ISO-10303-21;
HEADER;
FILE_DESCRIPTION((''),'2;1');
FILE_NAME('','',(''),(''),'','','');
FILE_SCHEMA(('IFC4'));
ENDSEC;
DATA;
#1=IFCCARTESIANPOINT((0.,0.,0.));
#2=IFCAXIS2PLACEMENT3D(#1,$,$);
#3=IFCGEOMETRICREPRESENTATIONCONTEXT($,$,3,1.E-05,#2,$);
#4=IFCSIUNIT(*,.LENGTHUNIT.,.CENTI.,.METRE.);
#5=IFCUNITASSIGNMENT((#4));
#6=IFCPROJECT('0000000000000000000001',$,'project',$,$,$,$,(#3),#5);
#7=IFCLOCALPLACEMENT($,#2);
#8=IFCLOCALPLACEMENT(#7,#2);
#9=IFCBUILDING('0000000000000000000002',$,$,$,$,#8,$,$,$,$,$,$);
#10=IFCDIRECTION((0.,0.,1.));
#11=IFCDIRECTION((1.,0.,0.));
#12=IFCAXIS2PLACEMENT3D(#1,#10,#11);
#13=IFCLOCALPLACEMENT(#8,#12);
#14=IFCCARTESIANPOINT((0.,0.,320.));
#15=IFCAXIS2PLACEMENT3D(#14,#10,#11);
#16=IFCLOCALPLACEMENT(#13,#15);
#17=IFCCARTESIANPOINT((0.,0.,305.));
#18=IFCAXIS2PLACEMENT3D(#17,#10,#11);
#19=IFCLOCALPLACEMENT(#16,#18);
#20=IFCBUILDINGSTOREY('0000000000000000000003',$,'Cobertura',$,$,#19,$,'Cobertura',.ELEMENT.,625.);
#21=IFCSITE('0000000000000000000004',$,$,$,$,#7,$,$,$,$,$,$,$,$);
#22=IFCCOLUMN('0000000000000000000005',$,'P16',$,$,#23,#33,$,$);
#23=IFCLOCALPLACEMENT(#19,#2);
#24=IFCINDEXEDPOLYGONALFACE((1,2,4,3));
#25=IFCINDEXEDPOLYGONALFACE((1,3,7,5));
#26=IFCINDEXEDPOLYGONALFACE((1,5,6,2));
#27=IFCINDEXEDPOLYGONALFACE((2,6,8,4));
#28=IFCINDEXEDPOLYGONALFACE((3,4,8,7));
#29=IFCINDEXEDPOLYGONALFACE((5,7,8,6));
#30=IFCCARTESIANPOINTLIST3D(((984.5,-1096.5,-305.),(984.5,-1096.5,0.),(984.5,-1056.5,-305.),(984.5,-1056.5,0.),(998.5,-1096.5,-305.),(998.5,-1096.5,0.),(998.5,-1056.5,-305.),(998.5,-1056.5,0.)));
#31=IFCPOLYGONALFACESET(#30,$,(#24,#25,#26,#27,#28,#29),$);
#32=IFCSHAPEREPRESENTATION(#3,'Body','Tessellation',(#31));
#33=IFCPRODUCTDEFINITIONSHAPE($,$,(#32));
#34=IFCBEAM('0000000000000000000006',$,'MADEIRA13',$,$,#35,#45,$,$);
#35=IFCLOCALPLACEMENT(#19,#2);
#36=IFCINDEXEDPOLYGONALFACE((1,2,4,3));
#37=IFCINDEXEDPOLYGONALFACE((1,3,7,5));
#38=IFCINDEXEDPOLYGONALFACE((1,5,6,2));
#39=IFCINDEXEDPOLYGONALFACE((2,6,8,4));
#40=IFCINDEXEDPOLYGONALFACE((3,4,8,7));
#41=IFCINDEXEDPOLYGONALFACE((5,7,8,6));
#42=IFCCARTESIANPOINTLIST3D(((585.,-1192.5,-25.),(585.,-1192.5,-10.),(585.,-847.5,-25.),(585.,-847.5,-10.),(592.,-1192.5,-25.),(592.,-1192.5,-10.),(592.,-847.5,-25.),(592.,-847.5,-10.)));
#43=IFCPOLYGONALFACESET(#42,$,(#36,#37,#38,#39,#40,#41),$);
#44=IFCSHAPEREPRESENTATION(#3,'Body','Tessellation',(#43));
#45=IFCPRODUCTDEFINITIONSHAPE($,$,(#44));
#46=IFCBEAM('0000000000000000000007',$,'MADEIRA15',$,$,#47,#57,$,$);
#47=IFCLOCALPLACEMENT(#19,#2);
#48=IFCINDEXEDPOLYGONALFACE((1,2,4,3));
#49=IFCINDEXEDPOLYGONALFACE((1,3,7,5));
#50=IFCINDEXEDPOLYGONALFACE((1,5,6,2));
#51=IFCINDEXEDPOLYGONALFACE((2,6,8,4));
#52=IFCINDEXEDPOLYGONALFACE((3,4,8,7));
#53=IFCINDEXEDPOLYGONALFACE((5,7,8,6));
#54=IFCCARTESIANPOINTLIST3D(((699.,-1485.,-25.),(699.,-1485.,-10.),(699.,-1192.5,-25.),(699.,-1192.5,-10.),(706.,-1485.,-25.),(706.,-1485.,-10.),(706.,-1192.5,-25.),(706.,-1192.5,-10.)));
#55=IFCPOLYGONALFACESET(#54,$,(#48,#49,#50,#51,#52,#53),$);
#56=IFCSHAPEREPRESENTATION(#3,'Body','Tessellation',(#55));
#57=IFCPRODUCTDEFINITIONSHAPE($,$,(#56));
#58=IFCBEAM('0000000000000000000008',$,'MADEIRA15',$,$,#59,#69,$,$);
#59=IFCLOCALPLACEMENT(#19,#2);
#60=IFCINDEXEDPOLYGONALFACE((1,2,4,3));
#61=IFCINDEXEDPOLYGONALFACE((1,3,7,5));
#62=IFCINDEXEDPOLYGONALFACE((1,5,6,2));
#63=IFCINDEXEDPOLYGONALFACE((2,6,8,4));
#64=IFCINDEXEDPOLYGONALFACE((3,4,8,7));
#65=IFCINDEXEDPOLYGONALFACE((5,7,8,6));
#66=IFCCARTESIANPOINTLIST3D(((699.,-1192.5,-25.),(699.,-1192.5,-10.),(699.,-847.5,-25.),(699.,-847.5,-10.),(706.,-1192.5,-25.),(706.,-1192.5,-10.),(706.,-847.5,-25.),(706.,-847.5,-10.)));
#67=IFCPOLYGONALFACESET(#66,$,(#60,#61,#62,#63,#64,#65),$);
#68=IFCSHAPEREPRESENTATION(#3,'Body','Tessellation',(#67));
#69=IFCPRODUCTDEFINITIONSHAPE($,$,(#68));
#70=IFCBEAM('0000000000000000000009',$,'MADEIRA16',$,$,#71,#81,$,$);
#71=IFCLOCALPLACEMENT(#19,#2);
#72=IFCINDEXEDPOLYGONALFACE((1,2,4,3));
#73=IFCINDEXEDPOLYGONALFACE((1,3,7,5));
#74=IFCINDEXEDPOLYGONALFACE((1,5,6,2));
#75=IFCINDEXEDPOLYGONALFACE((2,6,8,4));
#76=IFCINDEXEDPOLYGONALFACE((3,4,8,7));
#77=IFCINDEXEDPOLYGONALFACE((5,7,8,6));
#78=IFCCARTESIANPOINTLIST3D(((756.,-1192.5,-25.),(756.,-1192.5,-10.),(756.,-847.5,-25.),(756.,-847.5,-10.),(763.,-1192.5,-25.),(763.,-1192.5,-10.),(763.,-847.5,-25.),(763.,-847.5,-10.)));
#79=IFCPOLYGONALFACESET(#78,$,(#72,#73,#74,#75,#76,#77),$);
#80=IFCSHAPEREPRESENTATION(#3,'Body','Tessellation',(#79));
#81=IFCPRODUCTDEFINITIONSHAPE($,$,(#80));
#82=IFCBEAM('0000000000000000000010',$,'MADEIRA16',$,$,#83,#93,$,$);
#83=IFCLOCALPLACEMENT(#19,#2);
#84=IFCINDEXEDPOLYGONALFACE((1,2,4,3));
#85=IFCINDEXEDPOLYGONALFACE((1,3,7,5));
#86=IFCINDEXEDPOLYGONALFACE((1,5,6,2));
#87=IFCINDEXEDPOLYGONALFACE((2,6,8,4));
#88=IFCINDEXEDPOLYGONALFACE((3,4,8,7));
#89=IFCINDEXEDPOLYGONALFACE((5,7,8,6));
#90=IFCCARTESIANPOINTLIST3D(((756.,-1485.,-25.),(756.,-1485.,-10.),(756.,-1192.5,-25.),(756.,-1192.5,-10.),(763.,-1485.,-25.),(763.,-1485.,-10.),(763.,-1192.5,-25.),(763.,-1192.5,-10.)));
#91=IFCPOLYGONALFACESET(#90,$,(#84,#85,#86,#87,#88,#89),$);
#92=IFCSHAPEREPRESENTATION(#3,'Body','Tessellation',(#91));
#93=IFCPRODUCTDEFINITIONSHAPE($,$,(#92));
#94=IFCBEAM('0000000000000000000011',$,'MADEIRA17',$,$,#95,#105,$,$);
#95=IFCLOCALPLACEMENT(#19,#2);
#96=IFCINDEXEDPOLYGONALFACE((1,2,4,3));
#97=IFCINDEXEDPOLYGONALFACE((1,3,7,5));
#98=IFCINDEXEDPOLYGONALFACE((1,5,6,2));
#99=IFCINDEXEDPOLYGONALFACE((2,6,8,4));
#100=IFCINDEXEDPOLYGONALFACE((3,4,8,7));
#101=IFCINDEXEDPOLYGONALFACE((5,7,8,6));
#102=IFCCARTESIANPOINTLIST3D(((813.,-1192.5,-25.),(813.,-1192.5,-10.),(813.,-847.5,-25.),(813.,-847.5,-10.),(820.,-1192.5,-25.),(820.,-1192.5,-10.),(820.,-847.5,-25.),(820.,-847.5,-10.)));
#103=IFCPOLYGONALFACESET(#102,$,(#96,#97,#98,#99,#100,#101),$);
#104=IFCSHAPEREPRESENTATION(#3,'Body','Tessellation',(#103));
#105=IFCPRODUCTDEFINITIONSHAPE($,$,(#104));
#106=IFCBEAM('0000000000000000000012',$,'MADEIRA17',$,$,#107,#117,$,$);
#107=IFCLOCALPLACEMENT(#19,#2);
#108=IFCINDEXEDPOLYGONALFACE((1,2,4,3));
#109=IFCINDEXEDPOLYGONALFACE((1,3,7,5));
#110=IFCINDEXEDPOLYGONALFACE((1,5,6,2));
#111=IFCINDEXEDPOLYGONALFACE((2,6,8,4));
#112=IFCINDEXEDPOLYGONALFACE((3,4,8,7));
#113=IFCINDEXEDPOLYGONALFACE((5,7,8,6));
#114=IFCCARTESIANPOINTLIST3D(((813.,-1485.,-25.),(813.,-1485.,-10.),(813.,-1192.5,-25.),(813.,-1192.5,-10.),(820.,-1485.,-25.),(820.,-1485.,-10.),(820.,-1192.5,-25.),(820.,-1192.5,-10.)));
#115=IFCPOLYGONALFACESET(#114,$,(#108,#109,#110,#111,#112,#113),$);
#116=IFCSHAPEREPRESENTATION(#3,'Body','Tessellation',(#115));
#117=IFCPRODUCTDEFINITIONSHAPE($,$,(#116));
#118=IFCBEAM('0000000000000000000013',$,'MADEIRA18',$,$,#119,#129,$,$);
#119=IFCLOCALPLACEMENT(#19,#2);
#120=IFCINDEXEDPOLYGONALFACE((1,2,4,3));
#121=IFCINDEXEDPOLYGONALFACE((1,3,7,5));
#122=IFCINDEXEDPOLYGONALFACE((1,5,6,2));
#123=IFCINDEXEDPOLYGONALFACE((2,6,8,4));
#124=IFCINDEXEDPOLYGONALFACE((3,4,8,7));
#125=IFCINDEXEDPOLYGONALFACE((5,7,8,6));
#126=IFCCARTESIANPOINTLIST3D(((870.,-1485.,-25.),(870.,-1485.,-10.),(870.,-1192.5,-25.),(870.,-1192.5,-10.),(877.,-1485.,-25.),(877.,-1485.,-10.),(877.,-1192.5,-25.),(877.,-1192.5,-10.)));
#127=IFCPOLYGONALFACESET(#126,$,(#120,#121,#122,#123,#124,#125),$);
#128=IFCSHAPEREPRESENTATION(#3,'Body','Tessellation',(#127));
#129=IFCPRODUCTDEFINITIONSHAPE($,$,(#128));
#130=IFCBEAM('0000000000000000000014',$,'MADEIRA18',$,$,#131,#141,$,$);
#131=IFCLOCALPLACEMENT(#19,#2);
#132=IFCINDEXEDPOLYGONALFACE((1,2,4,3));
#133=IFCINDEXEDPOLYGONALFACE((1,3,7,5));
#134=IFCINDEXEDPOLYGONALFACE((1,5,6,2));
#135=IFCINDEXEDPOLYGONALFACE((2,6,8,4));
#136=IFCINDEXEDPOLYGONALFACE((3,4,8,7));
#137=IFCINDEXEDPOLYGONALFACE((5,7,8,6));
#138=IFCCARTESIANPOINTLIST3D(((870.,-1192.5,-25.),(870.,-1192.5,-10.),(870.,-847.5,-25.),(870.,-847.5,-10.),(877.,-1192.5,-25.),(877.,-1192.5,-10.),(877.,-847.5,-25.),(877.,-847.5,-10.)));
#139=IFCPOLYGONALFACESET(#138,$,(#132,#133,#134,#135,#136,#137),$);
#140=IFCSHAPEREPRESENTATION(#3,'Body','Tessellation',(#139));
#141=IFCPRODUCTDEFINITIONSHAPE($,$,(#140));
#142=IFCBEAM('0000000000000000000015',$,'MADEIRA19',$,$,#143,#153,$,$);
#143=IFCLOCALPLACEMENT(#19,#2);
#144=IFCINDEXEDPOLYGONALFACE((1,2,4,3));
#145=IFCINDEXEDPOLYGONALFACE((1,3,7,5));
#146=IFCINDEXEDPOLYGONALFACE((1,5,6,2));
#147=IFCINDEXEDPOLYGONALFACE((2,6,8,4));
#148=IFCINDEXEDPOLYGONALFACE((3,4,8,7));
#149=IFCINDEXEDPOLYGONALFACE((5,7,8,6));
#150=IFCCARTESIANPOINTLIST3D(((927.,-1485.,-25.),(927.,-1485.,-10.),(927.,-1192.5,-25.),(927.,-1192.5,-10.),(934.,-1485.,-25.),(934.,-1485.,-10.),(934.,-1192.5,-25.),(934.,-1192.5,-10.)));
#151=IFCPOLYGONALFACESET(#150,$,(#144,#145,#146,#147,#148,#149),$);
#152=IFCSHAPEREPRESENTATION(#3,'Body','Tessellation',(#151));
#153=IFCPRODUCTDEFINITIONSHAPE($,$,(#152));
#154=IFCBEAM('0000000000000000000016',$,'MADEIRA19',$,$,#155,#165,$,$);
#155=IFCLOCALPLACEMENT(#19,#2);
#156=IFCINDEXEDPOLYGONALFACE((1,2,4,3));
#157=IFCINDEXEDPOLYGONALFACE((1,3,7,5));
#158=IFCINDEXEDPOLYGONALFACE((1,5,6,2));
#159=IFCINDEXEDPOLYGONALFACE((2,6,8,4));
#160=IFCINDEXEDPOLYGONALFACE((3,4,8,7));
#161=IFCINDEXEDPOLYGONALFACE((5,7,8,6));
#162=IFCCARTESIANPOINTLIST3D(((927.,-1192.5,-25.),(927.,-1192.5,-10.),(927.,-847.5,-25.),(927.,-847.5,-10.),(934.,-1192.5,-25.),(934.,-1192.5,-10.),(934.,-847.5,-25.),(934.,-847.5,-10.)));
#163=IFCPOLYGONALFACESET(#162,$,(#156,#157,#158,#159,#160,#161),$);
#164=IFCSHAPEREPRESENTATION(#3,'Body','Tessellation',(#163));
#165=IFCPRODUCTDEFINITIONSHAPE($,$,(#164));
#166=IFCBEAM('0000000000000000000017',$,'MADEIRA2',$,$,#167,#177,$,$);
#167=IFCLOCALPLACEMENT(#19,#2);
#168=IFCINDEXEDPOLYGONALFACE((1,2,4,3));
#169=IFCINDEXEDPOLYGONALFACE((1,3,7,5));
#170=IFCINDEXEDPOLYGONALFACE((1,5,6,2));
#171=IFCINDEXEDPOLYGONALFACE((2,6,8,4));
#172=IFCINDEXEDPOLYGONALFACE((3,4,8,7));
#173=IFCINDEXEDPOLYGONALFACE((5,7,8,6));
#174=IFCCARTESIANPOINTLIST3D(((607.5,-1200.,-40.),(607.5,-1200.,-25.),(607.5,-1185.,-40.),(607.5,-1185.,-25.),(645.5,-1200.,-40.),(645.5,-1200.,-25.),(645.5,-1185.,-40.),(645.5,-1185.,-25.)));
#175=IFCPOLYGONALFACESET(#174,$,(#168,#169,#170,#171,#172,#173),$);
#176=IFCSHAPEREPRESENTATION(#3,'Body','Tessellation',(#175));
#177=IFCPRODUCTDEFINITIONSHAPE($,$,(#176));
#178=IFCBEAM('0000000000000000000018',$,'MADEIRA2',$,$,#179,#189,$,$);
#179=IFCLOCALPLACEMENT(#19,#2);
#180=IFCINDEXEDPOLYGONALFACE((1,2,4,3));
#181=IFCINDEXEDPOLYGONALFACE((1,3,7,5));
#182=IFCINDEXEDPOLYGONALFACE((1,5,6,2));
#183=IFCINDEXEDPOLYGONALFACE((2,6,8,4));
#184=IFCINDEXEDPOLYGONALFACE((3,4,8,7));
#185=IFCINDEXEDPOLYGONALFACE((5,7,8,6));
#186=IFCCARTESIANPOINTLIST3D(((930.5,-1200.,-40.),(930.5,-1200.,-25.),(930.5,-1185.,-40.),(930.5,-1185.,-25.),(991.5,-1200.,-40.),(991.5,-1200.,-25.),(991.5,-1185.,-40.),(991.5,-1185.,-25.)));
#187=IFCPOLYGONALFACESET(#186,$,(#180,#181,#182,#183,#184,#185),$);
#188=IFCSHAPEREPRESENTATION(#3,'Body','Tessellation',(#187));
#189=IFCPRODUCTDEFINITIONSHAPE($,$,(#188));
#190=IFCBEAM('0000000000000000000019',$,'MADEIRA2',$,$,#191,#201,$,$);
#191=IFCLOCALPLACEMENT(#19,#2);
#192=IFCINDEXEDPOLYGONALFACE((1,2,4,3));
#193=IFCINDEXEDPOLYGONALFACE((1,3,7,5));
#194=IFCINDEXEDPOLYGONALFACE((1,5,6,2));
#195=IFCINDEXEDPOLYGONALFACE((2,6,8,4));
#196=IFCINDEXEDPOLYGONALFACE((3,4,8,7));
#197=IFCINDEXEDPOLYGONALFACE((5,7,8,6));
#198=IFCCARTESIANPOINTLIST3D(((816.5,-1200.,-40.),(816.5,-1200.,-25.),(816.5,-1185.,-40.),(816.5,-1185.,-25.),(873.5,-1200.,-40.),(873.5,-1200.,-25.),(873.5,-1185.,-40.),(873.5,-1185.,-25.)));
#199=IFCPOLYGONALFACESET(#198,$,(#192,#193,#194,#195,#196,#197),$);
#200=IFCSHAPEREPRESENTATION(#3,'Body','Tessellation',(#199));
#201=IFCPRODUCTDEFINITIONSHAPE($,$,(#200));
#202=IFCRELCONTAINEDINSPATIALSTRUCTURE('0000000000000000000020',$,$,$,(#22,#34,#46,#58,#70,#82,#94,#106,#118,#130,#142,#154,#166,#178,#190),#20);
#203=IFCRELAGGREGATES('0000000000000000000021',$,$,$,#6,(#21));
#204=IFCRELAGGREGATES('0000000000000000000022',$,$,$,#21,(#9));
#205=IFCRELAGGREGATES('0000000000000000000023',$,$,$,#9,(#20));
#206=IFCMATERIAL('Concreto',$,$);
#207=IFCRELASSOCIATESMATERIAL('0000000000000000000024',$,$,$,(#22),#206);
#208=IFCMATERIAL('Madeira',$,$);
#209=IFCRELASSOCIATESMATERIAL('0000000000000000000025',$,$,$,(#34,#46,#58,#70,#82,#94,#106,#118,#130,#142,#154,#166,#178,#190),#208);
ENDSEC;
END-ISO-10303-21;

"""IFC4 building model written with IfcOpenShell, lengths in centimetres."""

from ifc_helpers import new_model, si_unit, frame, origin, origin_with_axes, place, context, project, spatial, polyline, outline, extrude, material, element, save


model = new_model("IFC4")

# Units and contexts
context_of_model = context(None, 3, precision=1e-05, world=origin())
ifc_project = project(units=[si_unit("LENGTHUNIT", "METRE", prefix="CENTI")], contexts=[context_of_model])

# Site, building, storey
site_placement = place(None, origin())
site = spatial("IfcSite", under=ifc_project, at=site_placement)
building_placement = place(site_placement, origin())
building = spatial("IfcBuilding", under=site, at=building_placement)
placement_1 = place(building_placement, origin_with_axes())
placement_2 = place(placement_1, frame((0.0, 0.0, 320.0), z_axis=(0.0, 0.0, 1.0), x_axis=(1.0, 0.0, 0.0)))
storey_placement = place(placement_2, frame((0.0, 0.0, 305.0), z_axis=(0.0, 0.0, 1.0), x_axis=(1.0, 0.0, 0.0)))
storey = spatial("IfcBuildingStorey", under=building, at=storey_placement, Name="Cobertura", LongName="Cobertura", CompositionType="ELEMENT", Elevation=625.0)

# Column
ifc_material_1 = material(Name="Concreto")
column_placement = place(storey_placement, frame((991.5, -1076.5, 0.0), z_axis=(0.0, 0.0, 1.0), x_axis=(1.0, 0.0, 0.0)))
element("IfcColumn", 1, at=column_placement, inside=storey, material=ifc_material_1, Name="P16", context=context_of_model, shape_type="SolidModel", body=[
    extrude(outline(polyline([(-7.0, -20.0), (7.0, -20.0), (7.0, 20.0), (-7.0, 20.0), (-7.0, -20.0)])), origin_with_axes(), (0.0, 0.0, -1.0), 305.0),
])

# Beams
ifc_material_2 = material(Name="Madeira")
beam_1_placement = place(storey_placement, frame((588.5, -1020.0, -10.0), z_axis=(0.0, 0.0, 1.0), x_axis=(1.0, 0.0, 0.0)))
element("IfcBeam", 2, at=beam_1_placement, inside=storey, material=ifc_material_2, Name="MADEIRA13", context=context_of_model, shape_type="SolidModel", body=[
    extrude(outline(polyline([(-3.5, -7.5), (-3.5, 7.5), (3.5, 7.5), (3.5, -7.5), (-3.5, -7.5)])), frame((0.0, -172.5, -7.5), z_axis=(0.0, 1.0, 0.0), x_axis=(1.0, 0.0, 0.0)), (0.0, 0.0, 1.0), 345.0),
])
beam_2_placement = place(storey_placement, frame((702.5, -1338.75, -10.0), z_axis=(0.0, 0.0, 1.0), x_axis=(1.0, 0.0, 0.0)))
element("IfcBeam", 3, at=beam_2_placement, inside=storey, material=ifc_material_2, Name="MADEIRA15", context=context_of_model, shape_type="SolidModel", body=[
    extrude(outline(polyline([(-3.5, -7.5), (-3.5, 7.5), (3.5, 7.5), (3.5, -7.5), (-3.5, -7.5)])), frame((0.0, -146.25, -7.5), z_axis=(0.0, 1.0, 0.0), x_axis=(1.0, 0.0, 0.0)), (0.0, 0.0, 1.0), 292.5),
])
for number, where, z_axis, x_axis, name in (
    (4, (702.5, -1020.0, -10.0), (0.0, 0.0, 1.0), (1.0, 0.0, 0.0), "MADEIRA15"),
    (5, (759.5, -1020.0, -10.0), (0.0, 0.0, 1.0), (1.0, 0.0, 0.0), "MADEIRA16"),
):
    element("IfcBeam", number, at=place(storey_placement, frame(where, z_axis=z_axis, x_axis=x_axis)), inside=storey, material=ifc_material_2, Name=name, context=context_of_model, shape_type="SolidModel", body=[
        extrude(outline(polyline([(-3.5, -7.5), (-3.5, 7.5), (3.5, 7.5), (3.5, -7.5), (-3.5, -7.5)])), frame((0.0, -172.5, -7.5), z_axis=(0.0, 1.0, 0.0), x_axis=(1.0, 0.0, 0.0)), (0.0, 0.0, 1.0), 345.0),
    ])
beam_3_placement = place(storey_placement, frame((759.5, -1338.75, -10.0), z_axis=(0.0, 0.0, 1.0), x_axis=(1.0, 0.0, 0.0)))
element("IfcBeam", 6, at=beam_3_placement, inside=storey, material=ifc_material_2, Name="MADEIRA16", context=context_of_model, shape_type="SolidModel", body=[
    extrude(outline(polyline([(-3.5, -7.5), (-3.5, 7.5), (3.5, 7.5), (3.5, -7.5), (-3.5, -7.5)])), frame((0.0, -146.25, -7.5), z_axis=(0.0, 1.0, 0.0), x_axis=(1.0, 0.0, 0.0)), (0.0, 0.0, 1.0), 292.5),
])
beam_4_placement = place(storey_placement, frame((816.5, -1020.0, -10.0), z_axis=(0.0, 0.0, 1.0), x_axis=(1.0, 0.0, 0.0)))
element("IfcBeam", 7, at=beam_4_placement, inside=storey, material=ifc_material_2, Name="MADEIRA17", context=context_of_model, shape_type="SolidModel", body=[
    extrude(outline(polyline([(-3.5, -7.5), (-3.5, 7.5), (3.5, 7.5), (3.5, -7.5), (-3.5, -7.5)])), frame((0.0, -172.5, -7.5), z_axis=(0.0, 1.0, 0.0), x_axis=(1.0, 0.0, 0.0)), (0.0, 0.0, 1.0), 345.0),
])
for number, where, z_axis, x_axis, name in (
    (8, (816.5, -1338.75, -10.0), (0.0, 0.0, 1.0), (1.0, 0.0, 0.0), "MADEIRA17"),
    (9, (873.5, -1338.75, -10.0), (0.0, 0.0, 1.0), (1.0, 0.0, 0.0), "MADEIRA18"),
):
    element("IfcBeam", number, at=place(storey_placement, frame(where, z_axis=z_axis, x_axis=x_axis)), inside=storey, material=ifc_material_2, Name=name, context=context_of_model, shape_type="SolidModel", body=[
        extrude(outline(polyline([(-3.5, -7.5), (-3.5, 7.5), (3.5, 7.5), (3.5, -7.5), (-3.5, -7.5)])), frame((0.0, -146.25, -7.5), z_axis=(0.0, 1.0, 0.0), x_axis=(1.0, 0.0, 0.0)), (0.0, 0.0, 1.0), 292.5),
    ])
beam_5_placement = place(storey_placement, frame((873.5, -1020.0, -10.0), z_axis=(0.0, 0.0, 1.0), x_axis=(1.0, 0.0, 0.0)))
element("IfcBeam", 10, at=beam_5_placement, inside=storey, material=ifc_material_2, Name="MADEIRA18", context=context_of_model, shape_type="SolidModel", body=[
    extrude(outline(polyline([(-3.5, -7.5), (-3.5, 7.5), (3.5, 7.5), (3.5, -7.5), (-3.5, -7.5)])), frame((0.0, -172.5, -7.5), z_axis=(0.0, 1.0, 0.0), x_axis=(1.0, 0.0, 0.0)), (0.0, 0.0, 1.0), 345.0),
])
beam_6_placement = place(storey_placement, frame((930.5, -1338.75, -10.0), z_axis=(0.0, 0.0, 1.0), x_axis=(1.0, 0.0, 0.0)))
element("IfcBeam", 11, at=beam_6_placement, inside=storey, material=ifc_material_2, Name="MADEIRA19", context=context_of_model, shape_type="SolidModel", body=[
    extrude(outline(polyline([(-3.5, -7.5), (-3.5, 7.5), (3.5, 7.5), (3.5, -7.5), (-3.5, -7.5)])), frame((0.0, -146.25, -7.5), z_axis=(0.0, 1.0, 0.0), x_axis=(1.0, 0.0, 0.0)), (0.0, 0.0, 1.0), 292.5),
])
beam_7_placement = place(storey_placement, frame((930.5, -1020.0, -10.0), z_axis=(0.0, 0.0, 1.0), x_axis=(1.0, 0.0, 0.0)))
element("IfcBeam", 12, at=beam_7_placement, inside=storey, material=ifc_material_2, Name="MADEIRA19", context=context_of_model, shape_type="SolidModel", body=[
    extrude(outline(polyline([(-3.5, -7.5), (-3.5, 7.5), (3.5, 7.5), (3.5, -7.5), (-3.5, -7.5)])), frame((0.0, -172.5, -7.5), z_axis=(0.0, 1.0, 0.0), x_axis=(1.0, 0.0, 0.0)), (0.0, 0.0, 1.0), 345.0),
])
beam_8_placement = place(storey_placement, frame((626.5, -1192.5, -25.0), z_axis=(0.0, 0.0, 1.0), x_axis=(1.0, 0.0, 0.0)))
element("IfcBeam", 13, at=beam_8_placement, inside=storey, material=ifc_material_2, Name="MADEIRA2", context=context_of_model, shape_type="SolidModel", body=[
    extrude(outline(polyline([(-7.5, -7.5), (-7.5, 7.5), (7.5, 7.5), (7.5, -7.5), (-7.5, -7.5)])), frame((-19.0, 0.0, -7.5), z_axis=(1.0, 0.0, 0.0), x_axis=(0.0, -1.0, 0.0)), (0.0, 0.0, 1.0), 38.0),
])
beam_9_placement = place(storey_placement, frame((961.0, -1192.5, -25.0), z_axis=(0.0, 0.0, 1.0), x_axis=(1.0, 0.0, 0.0)))
element("IfcBeam", 14, at=beam_9_placement, inside=storey, material=ifc_material_2, Name="MADEIRA2", context=context_of_model, shape_type="SolidModel", body=[
    extrude(outline(polyline([(-7.5, -7.5), (-7.5, 7.5), (7.5, 7.5), (7.5, -7.5), (-7.5, -7.5)])), frame((-30.5, 0.0, -7.5), z_axis=(1.0, 0.0, 0.0), x_axis=(0.0, -1.0, 0.0)), (0.0, 0.0, 1.0), 61.0),
])
for number, where, z_axis, x_axis, name in (
    (15, (845.0, -1192.5, -25.0), (0.0, 0.0, 1.0), (1.0, 0.0, 0.0), "MADEIRA2"),
):
    element("IfcBeam", number, at=place(storey_placement, frame(where, z_axis=z_axis, x_axis=x_axis)), inside=storey, material=ifc_material_2, Name=name, context=context_of_model, shape_type="SolidModel", body=[
        extrude(outline(polyline([(-7.5, -7.5), (-7.5, 7.5), (7.5, 7.5), (7.5, -7.5), (-7.5, -7.5)])), frame((-28.5, 0.0, -7.5), z_axis=(1.0, 0.0, 0.0), x_axis=(0.0, -1.0, 0.0)), (0.0, 0.0, 1.0), 57.0),
    ])

save(model, "model.ifc")
